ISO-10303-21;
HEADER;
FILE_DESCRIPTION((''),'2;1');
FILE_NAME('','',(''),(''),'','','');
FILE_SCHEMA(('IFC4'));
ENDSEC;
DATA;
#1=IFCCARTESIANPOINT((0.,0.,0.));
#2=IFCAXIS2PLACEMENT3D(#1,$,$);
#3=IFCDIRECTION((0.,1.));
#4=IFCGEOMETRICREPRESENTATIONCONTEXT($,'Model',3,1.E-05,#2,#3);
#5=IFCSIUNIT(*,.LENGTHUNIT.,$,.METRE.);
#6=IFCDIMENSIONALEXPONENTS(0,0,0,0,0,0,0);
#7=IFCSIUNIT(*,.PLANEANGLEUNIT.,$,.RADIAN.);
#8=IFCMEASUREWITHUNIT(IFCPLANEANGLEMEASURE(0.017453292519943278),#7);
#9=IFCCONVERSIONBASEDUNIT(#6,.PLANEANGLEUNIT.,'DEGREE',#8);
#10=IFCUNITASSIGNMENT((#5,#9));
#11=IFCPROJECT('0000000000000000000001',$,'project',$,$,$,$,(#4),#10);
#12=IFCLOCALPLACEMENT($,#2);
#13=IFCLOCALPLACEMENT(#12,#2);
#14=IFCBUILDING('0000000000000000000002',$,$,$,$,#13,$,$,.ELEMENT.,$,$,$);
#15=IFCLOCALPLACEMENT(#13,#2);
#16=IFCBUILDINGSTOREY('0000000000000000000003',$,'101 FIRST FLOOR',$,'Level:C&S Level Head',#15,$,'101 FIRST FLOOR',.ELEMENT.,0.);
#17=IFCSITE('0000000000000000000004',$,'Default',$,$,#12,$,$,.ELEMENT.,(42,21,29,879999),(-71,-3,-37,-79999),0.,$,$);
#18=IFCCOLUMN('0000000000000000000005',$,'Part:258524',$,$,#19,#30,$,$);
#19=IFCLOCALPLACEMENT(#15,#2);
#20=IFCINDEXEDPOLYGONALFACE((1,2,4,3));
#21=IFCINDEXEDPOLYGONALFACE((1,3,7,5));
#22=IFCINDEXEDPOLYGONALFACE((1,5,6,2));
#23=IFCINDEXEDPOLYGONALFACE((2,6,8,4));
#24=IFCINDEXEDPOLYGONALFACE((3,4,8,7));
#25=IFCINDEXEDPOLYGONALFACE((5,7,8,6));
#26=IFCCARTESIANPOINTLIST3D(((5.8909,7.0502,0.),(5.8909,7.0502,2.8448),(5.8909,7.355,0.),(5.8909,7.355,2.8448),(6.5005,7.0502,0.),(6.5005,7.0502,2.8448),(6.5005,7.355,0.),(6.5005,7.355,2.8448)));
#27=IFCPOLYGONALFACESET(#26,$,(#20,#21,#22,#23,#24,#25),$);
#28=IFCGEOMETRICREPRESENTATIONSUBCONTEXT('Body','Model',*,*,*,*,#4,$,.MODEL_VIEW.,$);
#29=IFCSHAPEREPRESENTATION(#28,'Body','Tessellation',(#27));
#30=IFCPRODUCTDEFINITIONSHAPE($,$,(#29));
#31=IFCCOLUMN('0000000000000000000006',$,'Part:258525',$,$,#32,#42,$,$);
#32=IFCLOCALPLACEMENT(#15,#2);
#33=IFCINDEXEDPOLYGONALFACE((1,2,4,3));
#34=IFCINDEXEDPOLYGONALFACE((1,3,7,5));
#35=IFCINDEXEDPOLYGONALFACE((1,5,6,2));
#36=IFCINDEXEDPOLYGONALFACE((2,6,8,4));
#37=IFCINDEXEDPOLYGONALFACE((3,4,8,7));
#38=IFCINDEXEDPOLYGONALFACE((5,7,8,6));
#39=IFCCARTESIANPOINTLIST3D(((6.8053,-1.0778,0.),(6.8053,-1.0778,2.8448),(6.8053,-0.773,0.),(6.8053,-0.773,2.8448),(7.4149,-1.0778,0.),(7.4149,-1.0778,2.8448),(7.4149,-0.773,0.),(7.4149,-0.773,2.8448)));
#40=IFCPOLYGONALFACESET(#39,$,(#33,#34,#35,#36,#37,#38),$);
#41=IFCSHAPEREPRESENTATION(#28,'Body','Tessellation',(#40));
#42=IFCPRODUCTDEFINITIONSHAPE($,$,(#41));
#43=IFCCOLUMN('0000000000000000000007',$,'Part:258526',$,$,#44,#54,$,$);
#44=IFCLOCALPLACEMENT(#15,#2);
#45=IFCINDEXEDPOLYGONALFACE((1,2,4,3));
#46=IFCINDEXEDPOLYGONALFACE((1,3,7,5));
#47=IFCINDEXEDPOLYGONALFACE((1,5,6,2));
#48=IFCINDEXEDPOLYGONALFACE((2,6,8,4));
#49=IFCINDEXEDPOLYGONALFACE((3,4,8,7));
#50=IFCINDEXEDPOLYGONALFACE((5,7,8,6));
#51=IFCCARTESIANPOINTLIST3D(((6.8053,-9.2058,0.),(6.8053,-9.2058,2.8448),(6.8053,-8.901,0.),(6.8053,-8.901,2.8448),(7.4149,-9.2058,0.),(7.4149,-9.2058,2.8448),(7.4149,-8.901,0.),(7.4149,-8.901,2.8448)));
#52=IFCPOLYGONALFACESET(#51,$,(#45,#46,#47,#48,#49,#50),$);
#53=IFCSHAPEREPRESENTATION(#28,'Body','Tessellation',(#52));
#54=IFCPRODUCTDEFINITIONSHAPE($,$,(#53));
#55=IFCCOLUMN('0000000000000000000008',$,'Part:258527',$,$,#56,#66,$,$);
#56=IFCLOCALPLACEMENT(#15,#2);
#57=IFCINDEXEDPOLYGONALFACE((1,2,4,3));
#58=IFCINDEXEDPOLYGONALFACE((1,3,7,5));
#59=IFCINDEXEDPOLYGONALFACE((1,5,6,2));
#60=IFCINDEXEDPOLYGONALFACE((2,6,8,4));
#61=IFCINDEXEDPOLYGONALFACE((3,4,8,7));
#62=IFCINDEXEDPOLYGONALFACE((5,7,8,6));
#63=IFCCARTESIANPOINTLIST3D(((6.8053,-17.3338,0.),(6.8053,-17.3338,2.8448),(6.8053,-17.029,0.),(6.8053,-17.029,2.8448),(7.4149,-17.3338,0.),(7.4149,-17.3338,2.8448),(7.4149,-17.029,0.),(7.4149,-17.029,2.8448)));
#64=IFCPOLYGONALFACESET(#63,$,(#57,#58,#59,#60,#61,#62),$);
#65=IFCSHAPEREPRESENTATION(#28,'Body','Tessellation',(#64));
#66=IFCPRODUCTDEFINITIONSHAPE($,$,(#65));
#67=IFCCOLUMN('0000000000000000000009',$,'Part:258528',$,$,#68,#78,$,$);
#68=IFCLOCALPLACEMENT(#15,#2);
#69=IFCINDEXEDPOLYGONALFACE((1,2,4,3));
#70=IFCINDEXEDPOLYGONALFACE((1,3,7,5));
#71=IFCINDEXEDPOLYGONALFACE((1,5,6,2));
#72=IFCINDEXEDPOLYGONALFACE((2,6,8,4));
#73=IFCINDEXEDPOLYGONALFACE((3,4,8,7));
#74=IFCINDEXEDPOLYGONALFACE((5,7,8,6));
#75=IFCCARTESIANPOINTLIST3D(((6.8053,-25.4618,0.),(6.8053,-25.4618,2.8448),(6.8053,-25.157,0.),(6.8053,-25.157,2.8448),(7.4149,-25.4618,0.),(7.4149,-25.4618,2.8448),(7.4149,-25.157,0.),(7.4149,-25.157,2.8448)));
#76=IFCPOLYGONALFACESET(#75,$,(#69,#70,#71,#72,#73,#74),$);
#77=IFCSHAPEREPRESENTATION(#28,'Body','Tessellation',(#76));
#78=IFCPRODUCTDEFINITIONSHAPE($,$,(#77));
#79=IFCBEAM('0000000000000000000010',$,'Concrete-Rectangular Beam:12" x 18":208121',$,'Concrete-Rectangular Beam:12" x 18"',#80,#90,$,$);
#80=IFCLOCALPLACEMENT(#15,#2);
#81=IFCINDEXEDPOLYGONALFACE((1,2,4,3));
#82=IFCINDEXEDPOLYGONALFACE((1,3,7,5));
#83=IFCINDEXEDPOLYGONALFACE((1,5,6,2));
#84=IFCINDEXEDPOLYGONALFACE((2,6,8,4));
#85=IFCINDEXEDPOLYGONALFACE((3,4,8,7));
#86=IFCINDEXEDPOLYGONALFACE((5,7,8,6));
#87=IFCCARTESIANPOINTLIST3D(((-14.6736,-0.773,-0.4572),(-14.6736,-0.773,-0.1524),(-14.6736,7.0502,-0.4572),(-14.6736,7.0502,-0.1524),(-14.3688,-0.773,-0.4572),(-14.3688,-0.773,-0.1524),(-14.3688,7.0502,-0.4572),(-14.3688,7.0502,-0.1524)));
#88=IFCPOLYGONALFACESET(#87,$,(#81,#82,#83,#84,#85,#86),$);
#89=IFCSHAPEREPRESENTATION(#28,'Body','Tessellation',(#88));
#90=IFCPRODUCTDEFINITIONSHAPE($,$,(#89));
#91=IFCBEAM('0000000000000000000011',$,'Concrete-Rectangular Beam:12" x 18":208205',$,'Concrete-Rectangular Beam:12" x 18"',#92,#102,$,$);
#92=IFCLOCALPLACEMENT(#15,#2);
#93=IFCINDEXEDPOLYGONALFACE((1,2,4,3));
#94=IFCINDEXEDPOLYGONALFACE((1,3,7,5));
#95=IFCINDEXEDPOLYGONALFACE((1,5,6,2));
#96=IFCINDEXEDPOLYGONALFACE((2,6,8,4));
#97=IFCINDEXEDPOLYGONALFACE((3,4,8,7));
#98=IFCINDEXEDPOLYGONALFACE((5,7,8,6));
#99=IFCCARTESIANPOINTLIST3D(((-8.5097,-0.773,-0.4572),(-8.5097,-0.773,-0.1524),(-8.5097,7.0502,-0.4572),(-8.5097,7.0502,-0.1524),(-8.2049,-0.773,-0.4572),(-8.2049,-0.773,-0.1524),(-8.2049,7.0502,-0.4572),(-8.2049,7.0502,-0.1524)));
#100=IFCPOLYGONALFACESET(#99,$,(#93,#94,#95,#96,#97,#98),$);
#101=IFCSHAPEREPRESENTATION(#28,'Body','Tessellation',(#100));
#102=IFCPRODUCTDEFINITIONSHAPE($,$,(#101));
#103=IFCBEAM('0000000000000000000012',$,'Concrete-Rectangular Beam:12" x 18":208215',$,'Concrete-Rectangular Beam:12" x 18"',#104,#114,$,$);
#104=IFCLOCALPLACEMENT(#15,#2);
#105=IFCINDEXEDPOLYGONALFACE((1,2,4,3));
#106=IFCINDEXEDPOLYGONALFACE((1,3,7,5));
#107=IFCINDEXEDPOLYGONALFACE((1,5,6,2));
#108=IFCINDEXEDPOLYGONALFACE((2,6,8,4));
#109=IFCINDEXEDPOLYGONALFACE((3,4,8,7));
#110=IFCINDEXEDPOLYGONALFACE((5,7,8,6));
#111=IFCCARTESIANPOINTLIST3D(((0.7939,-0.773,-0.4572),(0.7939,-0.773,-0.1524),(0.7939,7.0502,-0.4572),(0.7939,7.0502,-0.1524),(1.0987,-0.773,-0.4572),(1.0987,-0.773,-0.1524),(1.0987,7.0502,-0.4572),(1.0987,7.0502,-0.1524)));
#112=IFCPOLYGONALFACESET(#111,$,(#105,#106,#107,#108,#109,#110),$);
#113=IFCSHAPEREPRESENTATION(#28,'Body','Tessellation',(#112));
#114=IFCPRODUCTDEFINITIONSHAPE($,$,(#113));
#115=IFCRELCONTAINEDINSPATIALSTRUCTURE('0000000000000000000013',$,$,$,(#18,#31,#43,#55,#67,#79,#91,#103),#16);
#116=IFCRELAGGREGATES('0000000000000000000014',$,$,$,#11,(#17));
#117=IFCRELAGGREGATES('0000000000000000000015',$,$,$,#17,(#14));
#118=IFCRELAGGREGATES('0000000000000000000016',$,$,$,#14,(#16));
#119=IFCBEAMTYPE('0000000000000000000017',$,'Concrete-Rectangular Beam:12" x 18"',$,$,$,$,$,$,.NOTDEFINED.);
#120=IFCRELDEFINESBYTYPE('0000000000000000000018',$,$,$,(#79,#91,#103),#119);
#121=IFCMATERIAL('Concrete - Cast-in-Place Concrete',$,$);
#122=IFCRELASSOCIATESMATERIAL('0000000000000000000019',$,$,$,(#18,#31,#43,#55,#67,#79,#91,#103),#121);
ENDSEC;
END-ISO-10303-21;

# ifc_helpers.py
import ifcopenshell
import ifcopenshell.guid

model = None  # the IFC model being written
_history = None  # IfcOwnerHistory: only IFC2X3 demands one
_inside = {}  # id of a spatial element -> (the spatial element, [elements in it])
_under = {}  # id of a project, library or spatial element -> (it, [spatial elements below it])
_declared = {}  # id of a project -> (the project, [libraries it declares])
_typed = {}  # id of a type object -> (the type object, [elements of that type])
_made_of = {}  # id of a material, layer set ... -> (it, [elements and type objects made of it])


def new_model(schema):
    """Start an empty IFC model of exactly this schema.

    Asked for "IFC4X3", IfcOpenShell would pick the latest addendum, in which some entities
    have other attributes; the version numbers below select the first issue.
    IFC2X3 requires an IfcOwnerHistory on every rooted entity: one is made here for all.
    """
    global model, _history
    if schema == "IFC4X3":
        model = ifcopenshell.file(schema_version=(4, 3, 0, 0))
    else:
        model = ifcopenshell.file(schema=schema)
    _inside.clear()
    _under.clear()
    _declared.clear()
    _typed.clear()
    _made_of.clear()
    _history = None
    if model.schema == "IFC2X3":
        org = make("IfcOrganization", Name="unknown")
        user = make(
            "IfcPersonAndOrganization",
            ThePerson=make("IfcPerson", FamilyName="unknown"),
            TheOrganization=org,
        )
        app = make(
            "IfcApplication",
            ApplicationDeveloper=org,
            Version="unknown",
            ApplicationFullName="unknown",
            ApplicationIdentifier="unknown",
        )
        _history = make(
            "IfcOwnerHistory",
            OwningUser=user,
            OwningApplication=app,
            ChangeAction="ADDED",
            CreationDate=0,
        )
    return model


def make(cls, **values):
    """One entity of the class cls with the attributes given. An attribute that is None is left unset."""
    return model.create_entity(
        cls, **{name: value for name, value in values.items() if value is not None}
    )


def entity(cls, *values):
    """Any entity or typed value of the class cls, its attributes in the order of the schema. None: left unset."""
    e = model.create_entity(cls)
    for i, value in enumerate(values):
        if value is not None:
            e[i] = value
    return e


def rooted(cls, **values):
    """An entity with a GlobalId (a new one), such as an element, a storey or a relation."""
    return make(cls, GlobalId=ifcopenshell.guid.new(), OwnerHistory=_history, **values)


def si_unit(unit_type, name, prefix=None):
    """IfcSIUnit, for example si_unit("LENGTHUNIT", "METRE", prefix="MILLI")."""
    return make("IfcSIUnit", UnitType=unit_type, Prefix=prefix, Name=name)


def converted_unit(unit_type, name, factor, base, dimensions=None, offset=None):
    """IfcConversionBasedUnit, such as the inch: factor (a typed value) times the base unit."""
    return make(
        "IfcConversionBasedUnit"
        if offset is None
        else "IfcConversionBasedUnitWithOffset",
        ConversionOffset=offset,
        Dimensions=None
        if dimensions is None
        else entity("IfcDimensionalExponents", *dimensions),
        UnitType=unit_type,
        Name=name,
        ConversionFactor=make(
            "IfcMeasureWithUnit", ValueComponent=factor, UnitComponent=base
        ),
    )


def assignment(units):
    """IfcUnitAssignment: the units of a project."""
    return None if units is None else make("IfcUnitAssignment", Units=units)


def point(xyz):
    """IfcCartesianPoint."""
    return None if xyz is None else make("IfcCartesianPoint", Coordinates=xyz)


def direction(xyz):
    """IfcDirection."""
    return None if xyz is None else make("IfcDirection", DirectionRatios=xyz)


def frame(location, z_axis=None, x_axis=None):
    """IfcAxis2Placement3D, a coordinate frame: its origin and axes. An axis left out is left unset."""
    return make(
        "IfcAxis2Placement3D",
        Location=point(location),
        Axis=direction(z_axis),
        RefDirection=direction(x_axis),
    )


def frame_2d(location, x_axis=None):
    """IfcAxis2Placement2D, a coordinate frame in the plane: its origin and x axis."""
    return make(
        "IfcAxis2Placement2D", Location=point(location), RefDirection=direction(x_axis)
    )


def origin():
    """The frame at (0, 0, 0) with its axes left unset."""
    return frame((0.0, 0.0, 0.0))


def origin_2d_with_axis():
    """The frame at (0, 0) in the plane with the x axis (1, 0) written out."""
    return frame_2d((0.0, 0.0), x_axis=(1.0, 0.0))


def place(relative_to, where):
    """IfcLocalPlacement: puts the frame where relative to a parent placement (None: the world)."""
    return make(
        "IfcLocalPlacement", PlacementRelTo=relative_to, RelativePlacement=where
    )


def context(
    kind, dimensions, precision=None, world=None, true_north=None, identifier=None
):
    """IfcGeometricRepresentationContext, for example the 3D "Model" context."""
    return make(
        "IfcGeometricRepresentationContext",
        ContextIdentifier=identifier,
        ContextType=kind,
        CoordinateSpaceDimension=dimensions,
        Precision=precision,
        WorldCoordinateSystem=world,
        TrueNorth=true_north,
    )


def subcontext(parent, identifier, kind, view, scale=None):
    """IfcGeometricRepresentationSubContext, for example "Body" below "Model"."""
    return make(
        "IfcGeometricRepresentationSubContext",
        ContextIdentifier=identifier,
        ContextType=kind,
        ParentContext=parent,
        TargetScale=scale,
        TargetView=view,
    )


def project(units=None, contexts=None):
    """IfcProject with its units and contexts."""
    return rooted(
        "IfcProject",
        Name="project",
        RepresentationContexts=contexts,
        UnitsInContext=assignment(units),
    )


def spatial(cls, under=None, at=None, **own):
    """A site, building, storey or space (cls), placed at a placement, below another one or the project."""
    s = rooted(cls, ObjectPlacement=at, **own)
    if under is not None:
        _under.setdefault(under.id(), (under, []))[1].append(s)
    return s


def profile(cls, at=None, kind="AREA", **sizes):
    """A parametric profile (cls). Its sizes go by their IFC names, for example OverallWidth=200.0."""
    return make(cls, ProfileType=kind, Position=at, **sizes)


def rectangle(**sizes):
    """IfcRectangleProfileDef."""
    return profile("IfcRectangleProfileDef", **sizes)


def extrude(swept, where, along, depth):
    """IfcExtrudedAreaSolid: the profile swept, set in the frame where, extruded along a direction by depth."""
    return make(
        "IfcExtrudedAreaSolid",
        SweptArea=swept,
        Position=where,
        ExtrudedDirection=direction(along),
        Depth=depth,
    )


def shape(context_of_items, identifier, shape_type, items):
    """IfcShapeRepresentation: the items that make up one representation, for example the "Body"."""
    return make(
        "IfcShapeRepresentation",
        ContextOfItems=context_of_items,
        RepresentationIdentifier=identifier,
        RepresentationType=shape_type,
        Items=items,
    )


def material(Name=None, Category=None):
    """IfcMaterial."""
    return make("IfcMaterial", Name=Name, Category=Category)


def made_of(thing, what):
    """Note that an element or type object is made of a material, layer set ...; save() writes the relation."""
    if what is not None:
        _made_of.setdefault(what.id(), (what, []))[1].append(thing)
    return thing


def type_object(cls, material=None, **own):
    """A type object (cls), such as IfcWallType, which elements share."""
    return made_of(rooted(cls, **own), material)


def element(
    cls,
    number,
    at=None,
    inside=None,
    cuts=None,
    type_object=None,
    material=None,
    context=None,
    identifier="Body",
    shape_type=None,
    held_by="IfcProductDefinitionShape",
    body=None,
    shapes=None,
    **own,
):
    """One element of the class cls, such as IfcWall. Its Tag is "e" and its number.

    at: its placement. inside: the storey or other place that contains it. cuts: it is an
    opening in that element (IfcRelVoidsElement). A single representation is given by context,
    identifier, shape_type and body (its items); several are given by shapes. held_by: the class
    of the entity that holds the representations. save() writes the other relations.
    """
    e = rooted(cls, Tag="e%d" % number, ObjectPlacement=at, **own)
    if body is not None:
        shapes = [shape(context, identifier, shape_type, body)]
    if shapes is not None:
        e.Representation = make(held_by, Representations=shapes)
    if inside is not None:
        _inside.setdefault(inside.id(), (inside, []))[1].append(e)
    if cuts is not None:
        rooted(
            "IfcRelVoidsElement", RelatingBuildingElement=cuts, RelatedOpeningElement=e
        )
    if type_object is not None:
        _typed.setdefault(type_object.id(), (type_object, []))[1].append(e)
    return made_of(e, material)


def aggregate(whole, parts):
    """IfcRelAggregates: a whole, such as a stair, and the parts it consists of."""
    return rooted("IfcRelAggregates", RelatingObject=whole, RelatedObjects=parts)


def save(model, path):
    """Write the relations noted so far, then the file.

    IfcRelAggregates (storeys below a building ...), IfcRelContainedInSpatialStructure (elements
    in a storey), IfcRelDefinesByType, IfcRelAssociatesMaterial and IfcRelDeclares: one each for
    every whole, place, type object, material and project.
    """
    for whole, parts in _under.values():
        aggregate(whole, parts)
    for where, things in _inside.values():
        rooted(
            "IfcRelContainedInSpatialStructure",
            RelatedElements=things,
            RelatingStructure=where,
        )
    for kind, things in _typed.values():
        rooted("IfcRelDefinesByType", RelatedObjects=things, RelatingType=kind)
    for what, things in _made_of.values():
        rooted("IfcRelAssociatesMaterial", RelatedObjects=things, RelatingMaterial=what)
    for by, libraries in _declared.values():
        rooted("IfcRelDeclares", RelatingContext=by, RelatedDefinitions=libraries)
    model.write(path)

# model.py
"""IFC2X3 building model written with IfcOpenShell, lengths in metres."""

from ifc_helpers import new_model, entity, si_unit, converted_unit, direction, frame, frame_2d, origin, origin_2d_with_axis, place, context, subcontext, project, spatial, rectangle, extrude, material, type_object, element, save


model = new_model("IFC2X3")

# Units and contexts
model_context = context("Model", 3, precision=1e-05, world=origin(), true_north=direction((0.0, 1.0)))
body_context = subcontext(model_context, "Body", "Model", "MODEL_VIEW")
ifc_project = project(units=[si_unit("LENGTHUNIT", "METRE"), converted_unit("PLANEANGLEUNIT", "DEGREE", entity("IfcPlaneAngleMeasure", 0.017453292519943278), si_unit("PLANEANGLEUNIT", "RADIAN"), dimensions=[0, 0, 0, 0, 0, 0, 0])], contexts=[model_context])

# Site, building, storey
site_placement = place(None, origin())
site = spatial("IfcSite", under=ifc_project, at=site_placement, Name="Default", CompositionType="ELEMENT", RefLatitude=(42, 21, 29, 879999), RefLongitude=(-71, -3, -37, -79999), RefElevation=0.0)
building_placement = place(site_placement, origin())
building = spatial("IfcBuilding", under=site, at=building_placement, CompositionType="ELEMENT")
storey_placement = place(building_placement, origin())
storey = spatial("IfcBuildingStorey", under=building, at=storey_placement, Name="101 FIRST FLOOR", ObjectType="Level:C&S Level Head", LongName="101 FIRST FLOOR", CompositionType="ELEMENT", Elevation=0.0)

# Columns
ifc_material = material(Name="Concrete - Cast-in-Place Concrete")
column_1_placement = place(storey_placement, origin())
element("IfcColumn", 1, at=column_1_placement, inside=storey, material=ifc_material, Name="Part:258524", context=body_context, shape_type="SweptSolid", body=[
    extrude(rectangle(XDim=2.8448, YDim=0.3048, at=origin_2d_with_axis()), frame((5.8909, 7.2026, 1.4224), z_axis=(1.0, 0.0, 0.0), x_axis=(0.0, 0.0, -1.0)), (0.0, 0.0, 1.0), 0.6096),
])
column_2_placement = place(storey_placement, origin())
element("IfcColumn", 2, at=column_2_placement, inside=storey, material=ifc_material, Name="Part:258525", context=body_context, shape_type="SweptSolid", body=[
    extrude(rectangle(XDim=2.8448, YDim=0.3048, at=origin_2d_with_axis()), frame((6.8053, -0.9254, 1.4224), z_axis=(1.0, 0.0, 0.0), x_axis=(0.0, 0.0, -1.0)), (0.0, 0.0, 1.0), 0.6096),
])
column_3_placement = place(storey_placement, origin())
element("IfcColumn", 3, at=column_3_placement, inside=storey, material=ifc_material, Name="Part:258526", context=body_context, shape_type="SweptSolid", body=[
    extrude(rectangle(XDim=2.8448, YDim=0.3048, at=origin_2d_with_axis()), frame((6.8053, -9.0534, 1.4224), z_axis=(1.0, 0.0, 0.0), x_axis=(0.0, 0.0, -1.0)), (0.0, 0.0, 1.0), 0.6096),
])
column_4_placement = place(storey_placement, origin())
element("IfcColumn", 4, at=column_4_placement, inside=storey, material=ifc_material, Name="Part:258527", context=body_context, shape_type="SweptSolid", body=[
    extrude(rectangle(XDim=2.8448, YDim=0.3048, at=origin_2d_with_axis()), frame((6.8053, -17.1814, 1.4224), z_axis=(1.0, 0.0, 0.0), x_axis=(0.0, 0.0, -1.0)), (0.0, 0.0, 1.0), 0.6096),
])
column_5_placement = place(storey_placement, origin())
element("IfcColumn", 5, at=column_5_placement, inside=storey, material=ifc_material, Name="Part:258528", context=body_context, shape_type="SweptSolid", body=[
    extrude(rectangle(XDim=2.8448, YDim=0.3048, at=origin_2d_with_axis()), frame((6.8053, -25.3094, 1.4224), z_axis=(1.0, 0.0, 0.0), x_axis=(0.0, 0.0, -1.0)), (0.0, 0.0, 1.0), 0.6096),
])

# Beams
beam_type = type_object("IfcBeamType", Name="Concrete-Rectangular Beam:12\" x 18\"", PredefinedType="NOTDEFINED")
beam_1_placement = place(storey_placement, frame((-14.5212, 7.0502, 0.0), z_axis=(0.0, 0.0, 1.0), x_axis=(0.0, -1.0, 0.0)))
element("IfcBeam", 6, at=beam_1_placement, inside=storey, type_object=beam_type, material=ifc_material, Name="Concrete-Rectangular Beam:12\" x 18\":208121", ObjectType="Concrete-Rectangular Beam:12\" x 18\"", context=body_context, shape_type="SweptSolid", body=[
    extrude(rectangle(XDim=0.3048, YDim=0.3048, at=frame_2d((0.0, 0.0), x_axis=(1.0, 0.0))), frame((0.0, 0.0, -0.3048), z_axis=(1.0, 0.0, 0.0), x_axis=(0.0, 0.0, -1.0)), (0.0, 0.0, 1.0), 7.8232),
])
beam_2_placement = place(storey_placement, frame((-8.3573, 7.0502, 0.0), z_axis=(0.0, 0.0, 1.0), x_axis=(0.0, -1.0, 0.0)))
element("IfcBeam", 7, at=beam_2_placement, inside=storey, type_object=beam_type, material=ifc_material, Name="Concrete-Rectangular Beam:12\" x 18\":208205", ObjectType="Concrete-Rectangular Beam:12\" x 18\"", context=body_context, shape_type="SweptSolid", body=[
    extrude(rectangle(XDim=0.3048, YDim=0.3048, at=frame_2d((0.0, 0.0), x_axis=(1.0, 0.0))), frame((0.0, 0.0, -0.3048), z_axis=(1.0, 0.0, 0.0), x_axis=(0.0, 0.0, -1.0)), (0.0, 0.0, 1.0), 7.8232),
])
beam_3_placement = place(storey_placement, frame((0.9463, 7.0502, 0.0), z_axis=(0.0, 0.0, 1.0), x_axis=(0.0, -1.0, 0.0)))
element("IfcBeam", 8, at=beam_3_placement, inside=storey, type_object=beam_type, material=ifc_material, Name="Concrete-Rectangular Beam:12\" x 18\":208215", ObjectType="Concrete-Rectangular Beam:12\" x 18\"", context=body_context, shape_type="SweptSolid", body=[
    extrude(rectangle(XDim=0.3048, YDim=0.3048, at=frame_2d((0.0, 0.0), x_axis=(1.0, 0.0))), frame((0.0, 0.0, -0.3048), z_axis=(1.0, 0.0, 0.0), x_axis=(0.0, 0.0, -1.0)), (0.0, 0.0, 1.0), 7.8232),
])

save(model, "model.ifc")
